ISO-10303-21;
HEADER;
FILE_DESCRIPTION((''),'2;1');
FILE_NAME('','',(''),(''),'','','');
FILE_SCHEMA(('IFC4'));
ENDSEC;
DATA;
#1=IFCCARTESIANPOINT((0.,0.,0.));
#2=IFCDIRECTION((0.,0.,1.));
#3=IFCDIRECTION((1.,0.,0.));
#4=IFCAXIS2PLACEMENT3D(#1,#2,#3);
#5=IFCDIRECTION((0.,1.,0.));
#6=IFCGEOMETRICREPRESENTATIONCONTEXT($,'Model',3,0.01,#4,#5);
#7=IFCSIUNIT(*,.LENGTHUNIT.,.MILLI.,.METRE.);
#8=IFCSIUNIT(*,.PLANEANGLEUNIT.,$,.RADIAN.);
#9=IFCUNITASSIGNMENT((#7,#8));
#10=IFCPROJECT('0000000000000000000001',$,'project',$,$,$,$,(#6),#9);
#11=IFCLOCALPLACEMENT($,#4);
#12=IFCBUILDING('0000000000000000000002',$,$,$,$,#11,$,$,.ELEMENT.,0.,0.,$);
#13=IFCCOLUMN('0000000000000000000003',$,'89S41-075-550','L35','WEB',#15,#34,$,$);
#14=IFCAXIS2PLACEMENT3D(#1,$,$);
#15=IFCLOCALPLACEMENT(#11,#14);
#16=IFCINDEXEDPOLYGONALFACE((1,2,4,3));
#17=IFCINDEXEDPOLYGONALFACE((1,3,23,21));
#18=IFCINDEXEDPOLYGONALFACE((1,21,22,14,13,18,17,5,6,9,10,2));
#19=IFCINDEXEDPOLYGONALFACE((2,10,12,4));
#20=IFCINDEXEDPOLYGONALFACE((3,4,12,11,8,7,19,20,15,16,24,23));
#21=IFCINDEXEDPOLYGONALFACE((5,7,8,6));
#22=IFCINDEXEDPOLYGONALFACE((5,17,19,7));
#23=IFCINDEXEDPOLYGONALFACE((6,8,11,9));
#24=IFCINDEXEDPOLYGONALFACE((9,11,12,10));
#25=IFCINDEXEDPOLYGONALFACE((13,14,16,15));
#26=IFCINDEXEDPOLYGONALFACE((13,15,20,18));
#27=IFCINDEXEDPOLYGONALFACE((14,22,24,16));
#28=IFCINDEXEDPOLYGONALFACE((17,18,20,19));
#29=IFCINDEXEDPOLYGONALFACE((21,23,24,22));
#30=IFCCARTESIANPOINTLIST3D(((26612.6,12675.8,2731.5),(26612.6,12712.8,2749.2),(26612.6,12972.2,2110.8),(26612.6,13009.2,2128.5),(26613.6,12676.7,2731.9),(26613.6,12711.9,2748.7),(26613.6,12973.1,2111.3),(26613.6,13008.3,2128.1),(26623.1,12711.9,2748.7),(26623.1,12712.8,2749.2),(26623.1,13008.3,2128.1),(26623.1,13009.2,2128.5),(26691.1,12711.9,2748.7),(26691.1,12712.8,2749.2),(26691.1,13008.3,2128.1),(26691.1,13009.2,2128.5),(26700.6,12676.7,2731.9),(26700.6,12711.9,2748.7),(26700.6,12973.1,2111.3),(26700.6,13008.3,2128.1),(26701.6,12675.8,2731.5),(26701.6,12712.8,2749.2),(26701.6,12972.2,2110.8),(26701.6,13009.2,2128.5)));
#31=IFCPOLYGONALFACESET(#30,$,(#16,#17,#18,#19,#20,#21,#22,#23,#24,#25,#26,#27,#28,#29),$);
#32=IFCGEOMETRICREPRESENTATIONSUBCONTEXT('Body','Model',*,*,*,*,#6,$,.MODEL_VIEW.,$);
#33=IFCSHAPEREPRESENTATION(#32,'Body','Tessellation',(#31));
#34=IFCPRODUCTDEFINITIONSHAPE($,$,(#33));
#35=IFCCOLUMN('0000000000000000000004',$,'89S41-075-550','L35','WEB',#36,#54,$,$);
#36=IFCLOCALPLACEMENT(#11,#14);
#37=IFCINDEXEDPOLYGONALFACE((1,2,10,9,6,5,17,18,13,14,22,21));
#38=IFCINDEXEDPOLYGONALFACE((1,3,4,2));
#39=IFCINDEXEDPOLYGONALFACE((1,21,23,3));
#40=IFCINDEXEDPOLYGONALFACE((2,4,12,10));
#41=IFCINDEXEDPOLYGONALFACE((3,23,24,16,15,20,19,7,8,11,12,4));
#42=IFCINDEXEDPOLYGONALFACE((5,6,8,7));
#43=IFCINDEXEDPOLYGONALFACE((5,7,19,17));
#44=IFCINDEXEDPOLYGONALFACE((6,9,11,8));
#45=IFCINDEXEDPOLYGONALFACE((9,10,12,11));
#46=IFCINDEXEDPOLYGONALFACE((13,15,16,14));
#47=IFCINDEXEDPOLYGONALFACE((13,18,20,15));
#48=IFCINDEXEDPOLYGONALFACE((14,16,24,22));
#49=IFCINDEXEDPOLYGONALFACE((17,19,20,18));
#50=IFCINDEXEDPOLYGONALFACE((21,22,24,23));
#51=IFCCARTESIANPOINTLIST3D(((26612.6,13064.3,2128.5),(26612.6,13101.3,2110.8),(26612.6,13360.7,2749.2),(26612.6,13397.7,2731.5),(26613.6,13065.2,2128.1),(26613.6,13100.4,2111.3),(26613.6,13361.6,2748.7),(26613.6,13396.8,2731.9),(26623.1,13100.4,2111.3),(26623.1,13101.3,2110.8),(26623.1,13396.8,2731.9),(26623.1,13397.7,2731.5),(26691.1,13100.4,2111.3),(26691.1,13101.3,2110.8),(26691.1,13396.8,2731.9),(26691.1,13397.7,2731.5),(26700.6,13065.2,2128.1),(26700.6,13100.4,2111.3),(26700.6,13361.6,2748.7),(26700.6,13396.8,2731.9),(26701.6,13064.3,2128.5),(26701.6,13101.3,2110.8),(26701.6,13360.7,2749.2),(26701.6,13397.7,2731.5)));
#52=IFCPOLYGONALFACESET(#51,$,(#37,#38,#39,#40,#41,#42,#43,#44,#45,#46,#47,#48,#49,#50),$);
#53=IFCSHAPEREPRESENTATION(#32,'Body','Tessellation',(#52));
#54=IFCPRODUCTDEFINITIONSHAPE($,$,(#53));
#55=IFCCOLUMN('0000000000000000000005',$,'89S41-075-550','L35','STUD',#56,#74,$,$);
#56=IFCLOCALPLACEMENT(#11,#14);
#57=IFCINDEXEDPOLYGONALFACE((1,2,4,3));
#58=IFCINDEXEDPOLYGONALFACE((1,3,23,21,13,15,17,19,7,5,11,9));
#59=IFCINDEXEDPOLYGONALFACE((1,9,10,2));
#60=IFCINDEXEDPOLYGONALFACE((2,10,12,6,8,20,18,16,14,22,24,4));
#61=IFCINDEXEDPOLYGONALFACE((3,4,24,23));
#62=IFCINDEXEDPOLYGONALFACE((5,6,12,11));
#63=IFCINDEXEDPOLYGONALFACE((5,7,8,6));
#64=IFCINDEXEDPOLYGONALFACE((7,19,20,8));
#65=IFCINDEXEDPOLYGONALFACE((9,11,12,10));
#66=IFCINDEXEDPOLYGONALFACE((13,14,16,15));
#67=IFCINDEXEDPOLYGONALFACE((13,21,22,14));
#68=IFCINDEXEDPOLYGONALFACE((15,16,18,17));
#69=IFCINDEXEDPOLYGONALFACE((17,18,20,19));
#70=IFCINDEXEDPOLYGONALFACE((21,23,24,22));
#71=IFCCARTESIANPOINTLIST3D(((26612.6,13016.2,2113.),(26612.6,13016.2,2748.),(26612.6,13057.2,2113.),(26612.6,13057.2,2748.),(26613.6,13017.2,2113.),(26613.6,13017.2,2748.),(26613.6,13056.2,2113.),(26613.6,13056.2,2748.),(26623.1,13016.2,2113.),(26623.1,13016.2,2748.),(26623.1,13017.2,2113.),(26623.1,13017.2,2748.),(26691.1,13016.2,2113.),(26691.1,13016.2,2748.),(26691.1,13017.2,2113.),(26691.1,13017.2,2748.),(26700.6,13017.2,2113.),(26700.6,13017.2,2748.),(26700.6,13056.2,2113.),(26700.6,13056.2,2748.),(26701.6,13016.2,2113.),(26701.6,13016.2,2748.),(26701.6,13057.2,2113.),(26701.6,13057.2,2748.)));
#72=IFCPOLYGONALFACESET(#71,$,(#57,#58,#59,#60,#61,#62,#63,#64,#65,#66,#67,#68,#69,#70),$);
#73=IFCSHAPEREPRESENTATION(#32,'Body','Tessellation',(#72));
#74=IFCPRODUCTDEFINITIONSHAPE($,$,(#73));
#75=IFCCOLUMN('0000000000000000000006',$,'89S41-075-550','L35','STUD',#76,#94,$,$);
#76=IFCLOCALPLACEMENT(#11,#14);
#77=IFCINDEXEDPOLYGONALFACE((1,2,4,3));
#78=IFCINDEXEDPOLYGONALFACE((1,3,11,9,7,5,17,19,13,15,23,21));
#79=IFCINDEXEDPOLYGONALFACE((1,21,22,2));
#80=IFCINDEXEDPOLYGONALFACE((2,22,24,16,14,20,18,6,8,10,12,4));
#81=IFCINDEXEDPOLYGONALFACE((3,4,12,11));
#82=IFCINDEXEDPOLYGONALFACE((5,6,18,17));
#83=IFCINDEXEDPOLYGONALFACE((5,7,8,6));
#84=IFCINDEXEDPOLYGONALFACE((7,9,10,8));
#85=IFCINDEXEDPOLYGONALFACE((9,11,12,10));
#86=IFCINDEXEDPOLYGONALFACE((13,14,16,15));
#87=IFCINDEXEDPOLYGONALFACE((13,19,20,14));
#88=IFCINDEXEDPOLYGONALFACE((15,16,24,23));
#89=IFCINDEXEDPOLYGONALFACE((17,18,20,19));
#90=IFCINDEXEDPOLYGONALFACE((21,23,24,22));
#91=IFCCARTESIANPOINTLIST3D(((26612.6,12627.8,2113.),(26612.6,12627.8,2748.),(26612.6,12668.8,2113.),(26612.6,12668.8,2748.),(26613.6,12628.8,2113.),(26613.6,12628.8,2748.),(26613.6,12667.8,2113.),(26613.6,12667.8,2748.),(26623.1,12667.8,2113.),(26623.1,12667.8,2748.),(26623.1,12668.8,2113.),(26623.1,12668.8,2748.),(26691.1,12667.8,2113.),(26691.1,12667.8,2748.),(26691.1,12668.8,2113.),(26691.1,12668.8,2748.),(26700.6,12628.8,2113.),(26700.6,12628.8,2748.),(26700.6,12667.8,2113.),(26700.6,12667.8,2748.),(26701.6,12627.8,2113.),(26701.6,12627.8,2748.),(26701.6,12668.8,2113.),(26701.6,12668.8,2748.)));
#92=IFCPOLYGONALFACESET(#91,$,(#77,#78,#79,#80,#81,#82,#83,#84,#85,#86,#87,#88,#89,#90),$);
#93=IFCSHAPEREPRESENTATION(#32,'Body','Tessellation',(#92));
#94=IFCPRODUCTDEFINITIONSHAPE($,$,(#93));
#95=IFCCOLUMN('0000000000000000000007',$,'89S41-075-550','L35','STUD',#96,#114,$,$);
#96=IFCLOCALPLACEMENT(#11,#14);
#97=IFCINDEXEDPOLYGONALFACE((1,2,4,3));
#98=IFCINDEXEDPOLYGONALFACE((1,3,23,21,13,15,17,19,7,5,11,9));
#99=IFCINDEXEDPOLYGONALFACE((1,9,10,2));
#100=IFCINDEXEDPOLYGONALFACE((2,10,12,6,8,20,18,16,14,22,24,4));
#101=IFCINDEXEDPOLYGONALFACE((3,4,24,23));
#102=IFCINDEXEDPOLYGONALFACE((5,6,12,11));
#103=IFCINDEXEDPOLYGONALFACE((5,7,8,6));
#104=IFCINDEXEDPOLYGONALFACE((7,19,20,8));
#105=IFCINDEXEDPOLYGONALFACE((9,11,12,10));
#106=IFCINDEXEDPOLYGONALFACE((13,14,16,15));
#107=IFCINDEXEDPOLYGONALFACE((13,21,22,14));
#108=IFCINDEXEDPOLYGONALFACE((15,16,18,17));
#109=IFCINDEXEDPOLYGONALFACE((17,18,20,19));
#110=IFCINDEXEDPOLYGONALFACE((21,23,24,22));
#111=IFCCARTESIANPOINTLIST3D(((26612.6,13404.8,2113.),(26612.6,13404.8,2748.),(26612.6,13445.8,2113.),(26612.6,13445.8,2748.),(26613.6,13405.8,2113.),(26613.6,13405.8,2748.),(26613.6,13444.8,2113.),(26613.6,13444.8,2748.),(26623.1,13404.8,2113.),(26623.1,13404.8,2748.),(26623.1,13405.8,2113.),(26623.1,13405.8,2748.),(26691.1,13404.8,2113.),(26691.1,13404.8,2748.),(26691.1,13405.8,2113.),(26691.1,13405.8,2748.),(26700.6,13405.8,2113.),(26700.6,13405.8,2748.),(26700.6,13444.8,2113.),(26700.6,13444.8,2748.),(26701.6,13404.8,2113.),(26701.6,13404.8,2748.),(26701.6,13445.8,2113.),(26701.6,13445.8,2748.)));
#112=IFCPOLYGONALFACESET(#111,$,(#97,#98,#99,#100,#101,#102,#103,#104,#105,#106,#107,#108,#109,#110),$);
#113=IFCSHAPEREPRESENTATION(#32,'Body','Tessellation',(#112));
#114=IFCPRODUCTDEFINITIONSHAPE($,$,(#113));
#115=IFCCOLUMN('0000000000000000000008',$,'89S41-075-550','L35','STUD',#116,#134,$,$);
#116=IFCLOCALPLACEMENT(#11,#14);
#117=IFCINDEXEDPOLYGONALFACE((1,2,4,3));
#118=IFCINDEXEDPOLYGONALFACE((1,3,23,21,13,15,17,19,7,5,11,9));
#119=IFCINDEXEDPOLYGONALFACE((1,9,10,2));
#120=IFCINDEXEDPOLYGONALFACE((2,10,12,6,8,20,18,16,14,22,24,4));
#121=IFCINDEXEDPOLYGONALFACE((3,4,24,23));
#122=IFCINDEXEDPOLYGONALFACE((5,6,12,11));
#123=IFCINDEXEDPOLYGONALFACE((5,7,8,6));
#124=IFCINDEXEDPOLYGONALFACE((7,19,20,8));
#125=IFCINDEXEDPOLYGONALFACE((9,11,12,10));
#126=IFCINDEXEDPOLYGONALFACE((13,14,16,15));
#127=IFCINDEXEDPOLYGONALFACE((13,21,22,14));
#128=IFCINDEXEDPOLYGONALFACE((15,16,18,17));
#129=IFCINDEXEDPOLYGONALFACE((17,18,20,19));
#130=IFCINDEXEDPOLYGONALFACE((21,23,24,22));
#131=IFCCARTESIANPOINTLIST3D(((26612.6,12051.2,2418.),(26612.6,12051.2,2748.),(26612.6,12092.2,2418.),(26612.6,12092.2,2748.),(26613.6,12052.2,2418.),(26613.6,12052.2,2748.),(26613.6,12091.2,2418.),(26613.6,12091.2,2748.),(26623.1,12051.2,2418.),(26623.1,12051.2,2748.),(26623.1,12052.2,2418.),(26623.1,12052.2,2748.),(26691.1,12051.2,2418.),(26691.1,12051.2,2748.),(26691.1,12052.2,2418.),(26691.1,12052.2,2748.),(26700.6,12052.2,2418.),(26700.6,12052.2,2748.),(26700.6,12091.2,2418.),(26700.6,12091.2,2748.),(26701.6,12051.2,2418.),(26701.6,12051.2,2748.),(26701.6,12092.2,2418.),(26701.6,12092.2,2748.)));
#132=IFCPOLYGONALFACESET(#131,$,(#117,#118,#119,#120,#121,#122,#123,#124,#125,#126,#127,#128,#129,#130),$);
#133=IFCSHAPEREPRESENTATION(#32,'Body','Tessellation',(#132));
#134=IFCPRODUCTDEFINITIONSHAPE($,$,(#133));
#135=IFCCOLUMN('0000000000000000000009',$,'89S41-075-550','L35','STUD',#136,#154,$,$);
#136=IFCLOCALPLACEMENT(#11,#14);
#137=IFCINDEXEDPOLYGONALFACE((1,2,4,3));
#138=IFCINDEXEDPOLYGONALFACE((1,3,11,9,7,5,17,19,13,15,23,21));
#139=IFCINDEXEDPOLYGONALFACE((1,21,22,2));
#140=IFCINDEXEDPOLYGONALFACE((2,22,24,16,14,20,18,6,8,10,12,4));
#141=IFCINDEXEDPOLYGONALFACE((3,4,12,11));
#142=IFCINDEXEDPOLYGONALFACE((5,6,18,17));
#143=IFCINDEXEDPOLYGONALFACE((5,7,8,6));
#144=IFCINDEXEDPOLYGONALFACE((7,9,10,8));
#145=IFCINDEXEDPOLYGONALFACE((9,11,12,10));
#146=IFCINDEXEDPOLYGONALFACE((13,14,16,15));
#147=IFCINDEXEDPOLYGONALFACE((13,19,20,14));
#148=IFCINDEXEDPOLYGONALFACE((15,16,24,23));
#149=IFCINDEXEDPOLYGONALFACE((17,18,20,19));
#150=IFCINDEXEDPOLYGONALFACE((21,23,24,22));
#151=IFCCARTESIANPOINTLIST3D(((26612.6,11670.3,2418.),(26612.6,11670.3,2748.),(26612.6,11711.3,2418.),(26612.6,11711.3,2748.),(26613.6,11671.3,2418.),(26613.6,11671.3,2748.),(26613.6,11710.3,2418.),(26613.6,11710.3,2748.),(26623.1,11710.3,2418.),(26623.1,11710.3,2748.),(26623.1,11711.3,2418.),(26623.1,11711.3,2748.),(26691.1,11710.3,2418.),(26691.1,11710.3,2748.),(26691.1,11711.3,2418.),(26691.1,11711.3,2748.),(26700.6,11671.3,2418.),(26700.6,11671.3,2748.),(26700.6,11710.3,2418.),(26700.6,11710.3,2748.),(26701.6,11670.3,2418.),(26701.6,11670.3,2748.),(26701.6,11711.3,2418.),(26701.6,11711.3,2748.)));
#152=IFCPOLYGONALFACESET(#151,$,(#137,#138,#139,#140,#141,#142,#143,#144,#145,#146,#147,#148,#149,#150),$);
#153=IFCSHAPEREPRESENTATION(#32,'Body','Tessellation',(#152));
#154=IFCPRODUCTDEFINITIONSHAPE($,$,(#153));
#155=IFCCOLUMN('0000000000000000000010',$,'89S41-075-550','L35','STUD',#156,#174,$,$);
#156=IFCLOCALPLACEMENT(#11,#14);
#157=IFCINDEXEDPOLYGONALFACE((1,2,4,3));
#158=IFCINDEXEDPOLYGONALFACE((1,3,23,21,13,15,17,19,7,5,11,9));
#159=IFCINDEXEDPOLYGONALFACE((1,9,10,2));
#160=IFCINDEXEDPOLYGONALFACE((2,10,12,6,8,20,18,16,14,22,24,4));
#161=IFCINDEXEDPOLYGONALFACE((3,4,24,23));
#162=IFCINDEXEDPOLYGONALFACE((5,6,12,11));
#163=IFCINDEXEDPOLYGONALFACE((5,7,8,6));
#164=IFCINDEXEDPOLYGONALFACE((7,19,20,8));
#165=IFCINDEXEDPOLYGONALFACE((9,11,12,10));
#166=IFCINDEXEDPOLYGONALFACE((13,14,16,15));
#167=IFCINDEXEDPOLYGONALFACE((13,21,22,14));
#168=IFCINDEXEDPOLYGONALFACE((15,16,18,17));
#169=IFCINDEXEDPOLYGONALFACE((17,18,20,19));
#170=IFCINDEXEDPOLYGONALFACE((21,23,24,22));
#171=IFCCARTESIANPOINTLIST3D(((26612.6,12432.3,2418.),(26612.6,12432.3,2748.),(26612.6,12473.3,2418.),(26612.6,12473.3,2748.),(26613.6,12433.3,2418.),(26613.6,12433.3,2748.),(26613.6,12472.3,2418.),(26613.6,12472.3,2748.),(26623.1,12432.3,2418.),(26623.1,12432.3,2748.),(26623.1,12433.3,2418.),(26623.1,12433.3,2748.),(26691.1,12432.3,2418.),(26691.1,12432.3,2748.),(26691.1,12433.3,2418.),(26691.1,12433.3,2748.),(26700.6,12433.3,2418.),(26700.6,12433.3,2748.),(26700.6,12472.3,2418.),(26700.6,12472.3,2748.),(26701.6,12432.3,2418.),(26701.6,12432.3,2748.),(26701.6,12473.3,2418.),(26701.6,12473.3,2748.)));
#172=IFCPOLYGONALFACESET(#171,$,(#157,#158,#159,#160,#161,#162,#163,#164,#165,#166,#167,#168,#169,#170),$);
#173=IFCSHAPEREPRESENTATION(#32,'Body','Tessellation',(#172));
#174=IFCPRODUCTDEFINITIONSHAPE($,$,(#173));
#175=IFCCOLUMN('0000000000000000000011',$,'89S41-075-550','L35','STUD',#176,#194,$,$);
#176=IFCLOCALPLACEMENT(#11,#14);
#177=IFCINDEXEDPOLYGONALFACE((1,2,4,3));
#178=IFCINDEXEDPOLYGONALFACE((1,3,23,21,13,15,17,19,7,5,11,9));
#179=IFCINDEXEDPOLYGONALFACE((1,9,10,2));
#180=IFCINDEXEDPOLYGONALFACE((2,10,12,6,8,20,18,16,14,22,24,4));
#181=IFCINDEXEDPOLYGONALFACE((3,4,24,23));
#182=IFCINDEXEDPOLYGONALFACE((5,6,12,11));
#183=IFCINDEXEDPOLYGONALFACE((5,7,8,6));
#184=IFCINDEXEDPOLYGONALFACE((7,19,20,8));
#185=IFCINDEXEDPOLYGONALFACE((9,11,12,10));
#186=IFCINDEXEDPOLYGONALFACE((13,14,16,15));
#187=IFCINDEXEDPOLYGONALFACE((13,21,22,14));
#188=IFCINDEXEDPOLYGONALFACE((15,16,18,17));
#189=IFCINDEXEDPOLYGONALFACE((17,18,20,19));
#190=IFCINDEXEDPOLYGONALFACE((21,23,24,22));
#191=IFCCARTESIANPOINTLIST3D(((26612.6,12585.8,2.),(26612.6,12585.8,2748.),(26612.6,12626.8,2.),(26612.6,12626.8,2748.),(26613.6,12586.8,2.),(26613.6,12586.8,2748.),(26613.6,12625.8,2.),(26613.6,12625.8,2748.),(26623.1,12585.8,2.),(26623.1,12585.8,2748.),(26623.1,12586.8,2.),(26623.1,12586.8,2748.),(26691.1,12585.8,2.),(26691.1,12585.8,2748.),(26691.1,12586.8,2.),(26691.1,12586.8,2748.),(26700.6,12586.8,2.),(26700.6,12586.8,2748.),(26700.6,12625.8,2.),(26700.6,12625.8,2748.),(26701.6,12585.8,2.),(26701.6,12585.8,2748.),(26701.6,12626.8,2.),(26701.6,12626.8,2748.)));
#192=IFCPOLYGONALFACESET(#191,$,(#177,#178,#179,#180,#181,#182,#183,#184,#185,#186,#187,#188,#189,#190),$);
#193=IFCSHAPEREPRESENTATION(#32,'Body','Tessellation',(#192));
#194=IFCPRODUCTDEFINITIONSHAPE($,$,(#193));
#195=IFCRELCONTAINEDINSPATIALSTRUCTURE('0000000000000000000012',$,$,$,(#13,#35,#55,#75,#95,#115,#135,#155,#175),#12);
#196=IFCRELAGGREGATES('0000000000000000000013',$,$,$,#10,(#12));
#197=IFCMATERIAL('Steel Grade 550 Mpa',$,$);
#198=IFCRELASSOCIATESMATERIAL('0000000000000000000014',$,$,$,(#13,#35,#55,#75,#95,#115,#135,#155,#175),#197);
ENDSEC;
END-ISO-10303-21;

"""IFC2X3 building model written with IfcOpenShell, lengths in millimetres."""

from ifc_helpers import new_model, si_unit, direction, frame, origin, origin_with_axes, origin_2d_with_axis, place, context, subcontext, project, spatial, c_section, extrude, source, transform, mapped, material, element, save


model = new_model("IFC2X3")

# Units and contexts
model_context = context("Model", 3, precision=0.01, world=origin_with_axes(), true_north=direction((0.0, 1.0, 0.0)))
body_context = subcontext(model_context, "Body", "Model", "MODEL_VIEW")
ifc_project = project(units=[si_unit("LENGTHUNIT", "METRE", prefix="MILLI"), si_unit("PLANEANGLEUNIT", "RADIAN")], contexts=[model_context])

# Building
building_placement = place(None, origin_with_axes())
building = spatial("IfcBuilding", under=ifc_project, at=building_placement, CompositionType="ELEMENT", ElevationOfRefHeight=0.0, ElevationOfTerrain=0.0)

# Columns
ifc_material = material(Name="Steel Grade 550 Mpa")
shared_shape_1 = source(origin(), body_context, "Body", "SweptSolid", [
    extrude(c_section(Depth=89.0, Width=41.0, WallThickness=1.0, Girth=10.5, at=origin_2d_with_axis()), origin_with_axes(), (0.0, 0.0, 1.0), 687.8),
])
column_1_placement = place(None, frame((26657.1, 12990.7, 2119.7), z_axis=(0.0, -0.430861, 0.902418), x_axis=(0.0, 0.902418, 0.430861)))
element("IfcColumn", 1, at=column_1_placement, inside=building, material=ifc_material, Name="89S41-075-550", Description="L35", ObjectType="WEB", context=body_context, shape_type="MappedRepresentation", body=[
    mapped(shared_shape_1, transform((0.0, 0.0, 0.0), scale=1.0)),
])
shared_shape_2 = source(origin(), body_context, "Body", "SweptSolid", [
    extrude(c_section(Depth=89.0, Width=41.0, WallThickness=1.0, Girth=10.5, at=origin_2d_with_axis()), origin_with_axes(), (0.0, 0.0, 1.0), 687.8),
])
column_2_placement = place(None, frame((26657.1, 13082.8, 2119.7), z_axis=(0.0, 0.430877, 0.902411), x_axis=(0.0, 0.902411, -0.430877)))
element("IfcColumn", 2, at=column_2_placement, inside=building, material=ifc_material, Name="89S41-075-550", Description="L35", ObjectType="WEB", context=body_context, shape_type="MappedRepresentation", body=[
    mapped(shared_shape_2, transform((0.0, 0.0, 0.0), scale=1.0)),
])
shared_shape_3 = source(origin(), body_context, "Body", "SweptSolid", [
    extrude(c_section(Depth=89.0, Width=41.0, WallThickness=1.0, Girth=10.5, at=origin_2d_with_axis()), origin_with_axes(), (0.0, 0.0, 1.0), 635.0),
])
column_3_placement = place(None, frame((26657.1, 13036.7, 2113.0), z_axis=(0.0, 0.0, 1.0), x_axis=(0.0, -1.0, 0.0)))
element("IfcColumn", 3, at=column_3_placement, inside=building, material=ifc_material, Name="89S41-075-550", Description="L35", ObjectType="STUD", context=body_context, shape_type="MappedRepresentation", body=[
    mapped(shared_shape_3, transform((0.0, 0.0, 0.0), scale=1.0)),
])
shared_shape_4 = source(origin(), body_context, "Body", "SweptSolid", [
    extrude(c_section(Depth=89.0, Width=41.0, WallThickness=1.0, Girth=10.5, at=origin_2d_with_axis()), origin_with_axes(), (0.0, 0.0, 1.0), 635.0),
])
column_4_placement = place(None, frame((26657.1, 12648.3, 2113.0), z_axis=(0.0, 0.0, 1.0), x_axis=(0.0, 1.0, 0.0)))
element("IfcColumn", 4, at=column_4_placement, inside=building, material=ifc_material, Name="89S41-075-550", Description="L35", ObjectType="STUD", context=body_context, shape_type="MappedRepresentation", body=[
    mapped(shared_shape_4, transform((0.0, 0.0, 0.0), scale=1.0)),
])
shared_shape_5 = source(origin(), body_context, "Body", "SweptSolid", [
    extrude(c_section(Depth=89.0, Width=41.0, WallThickness=1.0, Girth=10.5, at=origin_2d_with_axis()), origin_with_axes(), (0.0, 0.0, 1.0), 635.0),
])
column_5_placement = place(None, frame((26657.1, 13425.3, 2113.0), z_axis=(0.0, 0.0, 1.0), x_axis=(0.0, -1.0, 0.0)))
element("IfcColumn", 5, at=column_5_placement, inside=building, material=ifc_material, Name="89S41-075-550", Description="L35", ObjectType="STUD", context=body_context, shape_type="MappedRepresentation", body=[
    mapped(shared_shape_5, transform((0.0, 0.0, 0.0), scale=1.0)),
])
shared_shape_6 = source(origin(), body_context, "Body", "SweptSolid", [
    extrude(c_section(Depth=89.0, Width=41.0, WallThickness=1.0, Girth=10.5, at=origin_2d_with_axis()), origin_with_axes(), (0.0, 0.0, 1.0), 330.0),
])
column_6_placement = place(None, frame((26657.1, 12071.7, 2418.0), z_axis=(0.0, 0.0, 1.0), x_axis=(0.0, -1.0, 0.0)))
element("IfcColumn", 6, at=column_6_placement, inside=building, material=ifc_material, Name="89S41-075-550", Description="L35", ObjectType="STUD", context=body_context, shape_type="MappedRepresentation", body=[
    mapped(shared_shape_6, transform((0.0, 0.0, 0.0), scale=1.0)),
])
shared_shape_7 = source(origin(), body_context, "Body", "SweptSolid", [
    extrude(c_section(Depth=89.0, Width=41.0, WallThickness=1.0, Girth=10.5, at=origin_2d_with_axis()), origin_with_axes(), (0.0, 0.0, 1.0), 330.0),
])
column_7_placement = place(None, frame((26657.1, 11690.8, 2418.0), z_axis=(0.0, 0.0, 1.0), x_axis=(0.0, 1.0, 0.0)))
element("IfcColumn", 7, at=column_7_placement, inside=building, material=ifc_material, Name="89S41-075-550", Description="L35", ObjectType="STUD", context=body_context, shape_type="MappedRepresentation", body=[
    mapped(shared_shape_7, transform((0.0, 0.0, 0.0), scale=1.0)),
])
shared_shape_8 = source(origin(), body_context, "Body", "SweptSolid", [
    extrude(c_section(Depth=89.0, Width=41.0, WallThickness=1.0, Girth=10.5, at=origin_2d_with_axis()), origin_with_axes(), (0.0, 0.0, 1.0), 330.0),
])
column_8_placement = place(None, frame((26657.1, 12452.8, 2418.0), z_axis=(0.0, 0.0, 1.0), x_axis=(0.0, -1.0, 0.0)))
element("IfcColumn", 8, at=column_8_placement, inside=building, material=ifc_material, Name="89S41-075-550", Description="L35", ObjectType="STUD", context=body_context, shape_type="MappedRepresentation", body=[
    mapped(shared_shape_8, transform((0.0, 0.0, 0.0), scale=1.0)),
])
shared_shape_9 = source(origin(), body_context, "Body", "SweptSolid", [
    extrude(c_section(Depth=89.0, Width=41.0, WallThickness=1.0, Girth=10.5, at=origin_2d_with_axis()), origin_with_axes(), (0.0, 0.0, 1.0), 2746.0),
])
column_9_placement = place(None, frame((26657.1, 12606.3, 2.0), z_axis=(0.0, 0.0, 1.0), x_axis=(0.0, -1.0, 0.0)))
element("IfcColumn", 9, at=column_9_placement, inside=building, material=ifc_material, Name="89S41-075-550", Description="L35", ObjectType="STUD", context=body_context, shape_type="MappedRepresentation", body=[
    mapped(shared_shape_9, transform((0.0, 0.0, 0.0), scale=1.0)),
])

save(model, "model.ifc")
